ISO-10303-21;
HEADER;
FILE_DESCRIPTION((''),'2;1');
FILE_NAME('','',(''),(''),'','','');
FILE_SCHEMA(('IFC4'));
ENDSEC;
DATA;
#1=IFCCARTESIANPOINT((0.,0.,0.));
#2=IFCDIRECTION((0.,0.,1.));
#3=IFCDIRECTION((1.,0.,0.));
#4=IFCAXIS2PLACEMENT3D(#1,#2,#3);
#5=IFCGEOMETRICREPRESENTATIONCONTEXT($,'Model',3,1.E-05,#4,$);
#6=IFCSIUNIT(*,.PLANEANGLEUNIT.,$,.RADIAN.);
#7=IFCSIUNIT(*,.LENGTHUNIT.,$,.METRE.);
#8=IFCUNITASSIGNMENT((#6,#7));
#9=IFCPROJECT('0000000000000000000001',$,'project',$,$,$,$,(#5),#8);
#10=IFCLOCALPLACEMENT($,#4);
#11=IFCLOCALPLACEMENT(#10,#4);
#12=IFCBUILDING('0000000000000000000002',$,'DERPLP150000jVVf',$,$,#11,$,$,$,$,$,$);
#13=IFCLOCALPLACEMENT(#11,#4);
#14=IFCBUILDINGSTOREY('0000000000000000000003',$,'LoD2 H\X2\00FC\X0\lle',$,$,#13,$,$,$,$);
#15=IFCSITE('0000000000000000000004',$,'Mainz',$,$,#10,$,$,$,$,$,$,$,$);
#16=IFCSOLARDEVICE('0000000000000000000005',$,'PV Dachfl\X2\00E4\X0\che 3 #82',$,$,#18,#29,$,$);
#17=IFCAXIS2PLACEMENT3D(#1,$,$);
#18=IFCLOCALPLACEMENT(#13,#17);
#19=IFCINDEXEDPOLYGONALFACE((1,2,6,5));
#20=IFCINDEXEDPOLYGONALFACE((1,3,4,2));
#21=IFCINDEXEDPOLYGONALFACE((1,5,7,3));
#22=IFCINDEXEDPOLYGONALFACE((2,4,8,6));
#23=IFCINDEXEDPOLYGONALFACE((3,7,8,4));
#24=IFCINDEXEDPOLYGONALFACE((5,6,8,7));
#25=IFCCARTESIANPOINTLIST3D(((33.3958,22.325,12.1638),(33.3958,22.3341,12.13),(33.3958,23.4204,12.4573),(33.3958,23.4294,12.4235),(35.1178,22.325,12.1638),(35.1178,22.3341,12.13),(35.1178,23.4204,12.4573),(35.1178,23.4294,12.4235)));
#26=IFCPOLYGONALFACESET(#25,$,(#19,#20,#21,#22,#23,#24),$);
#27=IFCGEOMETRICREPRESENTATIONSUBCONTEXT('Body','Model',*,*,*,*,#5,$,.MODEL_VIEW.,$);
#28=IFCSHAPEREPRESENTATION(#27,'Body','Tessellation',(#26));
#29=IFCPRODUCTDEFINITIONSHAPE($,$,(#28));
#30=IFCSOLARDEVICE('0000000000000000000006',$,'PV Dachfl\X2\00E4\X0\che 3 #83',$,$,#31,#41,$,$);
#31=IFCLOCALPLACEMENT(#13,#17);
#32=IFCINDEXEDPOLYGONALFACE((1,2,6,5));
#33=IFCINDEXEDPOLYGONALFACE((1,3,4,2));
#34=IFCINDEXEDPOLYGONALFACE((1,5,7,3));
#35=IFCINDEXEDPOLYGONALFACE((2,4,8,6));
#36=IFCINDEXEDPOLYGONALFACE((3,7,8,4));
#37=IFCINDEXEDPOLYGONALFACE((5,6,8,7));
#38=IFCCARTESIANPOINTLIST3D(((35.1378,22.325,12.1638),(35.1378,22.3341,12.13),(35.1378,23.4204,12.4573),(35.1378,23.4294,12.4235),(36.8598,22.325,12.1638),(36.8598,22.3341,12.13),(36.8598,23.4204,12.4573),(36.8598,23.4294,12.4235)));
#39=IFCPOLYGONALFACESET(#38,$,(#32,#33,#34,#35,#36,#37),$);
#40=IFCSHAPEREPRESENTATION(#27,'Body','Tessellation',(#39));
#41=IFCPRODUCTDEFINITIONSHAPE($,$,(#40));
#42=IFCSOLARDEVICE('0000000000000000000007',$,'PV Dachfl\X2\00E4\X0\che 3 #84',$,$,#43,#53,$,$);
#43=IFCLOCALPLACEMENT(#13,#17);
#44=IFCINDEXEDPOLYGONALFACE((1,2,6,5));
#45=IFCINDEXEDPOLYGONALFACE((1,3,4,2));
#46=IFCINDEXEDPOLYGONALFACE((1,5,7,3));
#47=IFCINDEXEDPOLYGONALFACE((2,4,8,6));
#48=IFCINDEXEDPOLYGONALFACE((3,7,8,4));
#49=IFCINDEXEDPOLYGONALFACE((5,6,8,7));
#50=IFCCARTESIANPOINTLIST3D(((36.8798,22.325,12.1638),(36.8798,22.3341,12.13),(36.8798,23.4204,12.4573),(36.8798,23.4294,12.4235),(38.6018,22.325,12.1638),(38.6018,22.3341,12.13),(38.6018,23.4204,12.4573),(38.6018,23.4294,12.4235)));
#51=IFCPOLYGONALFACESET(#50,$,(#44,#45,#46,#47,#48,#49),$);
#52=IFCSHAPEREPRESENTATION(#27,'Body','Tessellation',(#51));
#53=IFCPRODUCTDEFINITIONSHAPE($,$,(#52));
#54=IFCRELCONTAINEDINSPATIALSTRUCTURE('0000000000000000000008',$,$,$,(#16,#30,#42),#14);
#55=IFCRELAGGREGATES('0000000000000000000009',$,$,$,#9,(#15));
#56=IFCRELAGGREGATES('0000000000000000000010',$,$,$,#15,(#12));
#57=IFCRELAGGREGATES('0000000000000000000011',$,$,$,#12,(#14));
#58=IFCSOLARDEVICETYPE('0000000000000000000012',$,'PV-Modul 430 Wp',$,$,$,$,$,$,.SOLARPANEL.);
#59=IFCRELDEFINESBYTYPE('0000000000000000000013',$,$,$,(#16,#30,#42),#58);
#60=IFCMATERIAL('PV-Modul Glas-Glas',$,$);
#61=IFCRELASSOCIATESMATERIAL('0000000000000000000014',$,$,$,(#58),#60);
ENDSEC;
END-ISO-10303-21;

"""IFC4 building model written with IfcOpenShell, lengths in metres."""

from ifc_helpers import new_model, si_unit, frame, frame_2d, origin, origin_with_axes, place, context, subcontext, project, spatial, rectangle, extrude, source, transform, mapped, material, type_object, type_shapes, element, save


model = new_model("IFC4")

# Units and contexts
model_context = context("Model", 3, precision=1e-05, world=origin_with_axes())
body_context = subcontext(model_context, "Body", "Model", "MODEL_VIEW")
ifc_project = project(units=[si_unit("PLANEANGLEUNIT", "RADIAN"), si_unit("LENGTHUNIT", "METRE")], contexts=[model_context])

# Site, building, storey
site_placement = place(None, origin_with_axes())
site = spatial("IfcSite", under=ifc_project, at=site_placement, Name="Mainz")
building_placement = place(site_placement, origin_with_axes())
building = spatial("IfcBuilding", under=site, at=building_placement, Name="DERPLP150000jVVf")
storey_placement = place(building_placement, origin_with_axes())
storey = spatial("IfcBuildingStorey", under=building, at=storey_placement, Name="LoD2 Hülle")

# Solar devices
ifc_material = material(Name="PV-Modul Glas-Glas")
solar_device_type = type_object("IfcSolarDeviceType", Name="PV-Modul 430 Wp", PredefinedType="SOLARPANEL", material=ifc_material)
shared_shape = source(origin_with_axes(), body_context, "Body", "SweptSolid", [
    extrude(rectangle(XDim=1.722, YDim=1.134, at=frame_2d((0.861, 0.567))), origin(), (0.0, 0.0, 1.0), 0.035),
])
type_shapes(solar_device_type, [shared_shape])
for number, where, z_axis, x_axis, name in (
    (1, (33.3958, 22.3341, 12.13), (0.0, -0.258819, 0.965926), (1.0, 0.0, 0.0), "PV Dachfläche 3 #82"),
    (2, (35.1378, 22.3341, 12.13), (0.0, -0.258819, 0.965926), (1.0, 0.0, 0.0), "PV Dachfläche 3 #83"),
    (3, (36.8798, 22.3341, 12.13), (0.0, -0.258819, 0.965926), (1.0, 0.0, 0.0), "PV Dachfläche 3 #84"),
):
    element("IfcSolarDevice", number, at=place(storey_placement, frame(where, z_axis=z_axis, x_axis=x_axis)), inside=storey, type_object=solar_device_type, Name=name, context=body_context, shape_type="MappedRepresentation", body=[
        mapped(shared_shape, transform((0.0, 0.0, 0.0), x_axis=(1.0, 0.0, 0.0), y_axis=(0.0, 1.0, 0.0), z_axis=(0.0, 0.0, 1.0), scale=1.0)),
    ])

save(model, "model.ifc")
